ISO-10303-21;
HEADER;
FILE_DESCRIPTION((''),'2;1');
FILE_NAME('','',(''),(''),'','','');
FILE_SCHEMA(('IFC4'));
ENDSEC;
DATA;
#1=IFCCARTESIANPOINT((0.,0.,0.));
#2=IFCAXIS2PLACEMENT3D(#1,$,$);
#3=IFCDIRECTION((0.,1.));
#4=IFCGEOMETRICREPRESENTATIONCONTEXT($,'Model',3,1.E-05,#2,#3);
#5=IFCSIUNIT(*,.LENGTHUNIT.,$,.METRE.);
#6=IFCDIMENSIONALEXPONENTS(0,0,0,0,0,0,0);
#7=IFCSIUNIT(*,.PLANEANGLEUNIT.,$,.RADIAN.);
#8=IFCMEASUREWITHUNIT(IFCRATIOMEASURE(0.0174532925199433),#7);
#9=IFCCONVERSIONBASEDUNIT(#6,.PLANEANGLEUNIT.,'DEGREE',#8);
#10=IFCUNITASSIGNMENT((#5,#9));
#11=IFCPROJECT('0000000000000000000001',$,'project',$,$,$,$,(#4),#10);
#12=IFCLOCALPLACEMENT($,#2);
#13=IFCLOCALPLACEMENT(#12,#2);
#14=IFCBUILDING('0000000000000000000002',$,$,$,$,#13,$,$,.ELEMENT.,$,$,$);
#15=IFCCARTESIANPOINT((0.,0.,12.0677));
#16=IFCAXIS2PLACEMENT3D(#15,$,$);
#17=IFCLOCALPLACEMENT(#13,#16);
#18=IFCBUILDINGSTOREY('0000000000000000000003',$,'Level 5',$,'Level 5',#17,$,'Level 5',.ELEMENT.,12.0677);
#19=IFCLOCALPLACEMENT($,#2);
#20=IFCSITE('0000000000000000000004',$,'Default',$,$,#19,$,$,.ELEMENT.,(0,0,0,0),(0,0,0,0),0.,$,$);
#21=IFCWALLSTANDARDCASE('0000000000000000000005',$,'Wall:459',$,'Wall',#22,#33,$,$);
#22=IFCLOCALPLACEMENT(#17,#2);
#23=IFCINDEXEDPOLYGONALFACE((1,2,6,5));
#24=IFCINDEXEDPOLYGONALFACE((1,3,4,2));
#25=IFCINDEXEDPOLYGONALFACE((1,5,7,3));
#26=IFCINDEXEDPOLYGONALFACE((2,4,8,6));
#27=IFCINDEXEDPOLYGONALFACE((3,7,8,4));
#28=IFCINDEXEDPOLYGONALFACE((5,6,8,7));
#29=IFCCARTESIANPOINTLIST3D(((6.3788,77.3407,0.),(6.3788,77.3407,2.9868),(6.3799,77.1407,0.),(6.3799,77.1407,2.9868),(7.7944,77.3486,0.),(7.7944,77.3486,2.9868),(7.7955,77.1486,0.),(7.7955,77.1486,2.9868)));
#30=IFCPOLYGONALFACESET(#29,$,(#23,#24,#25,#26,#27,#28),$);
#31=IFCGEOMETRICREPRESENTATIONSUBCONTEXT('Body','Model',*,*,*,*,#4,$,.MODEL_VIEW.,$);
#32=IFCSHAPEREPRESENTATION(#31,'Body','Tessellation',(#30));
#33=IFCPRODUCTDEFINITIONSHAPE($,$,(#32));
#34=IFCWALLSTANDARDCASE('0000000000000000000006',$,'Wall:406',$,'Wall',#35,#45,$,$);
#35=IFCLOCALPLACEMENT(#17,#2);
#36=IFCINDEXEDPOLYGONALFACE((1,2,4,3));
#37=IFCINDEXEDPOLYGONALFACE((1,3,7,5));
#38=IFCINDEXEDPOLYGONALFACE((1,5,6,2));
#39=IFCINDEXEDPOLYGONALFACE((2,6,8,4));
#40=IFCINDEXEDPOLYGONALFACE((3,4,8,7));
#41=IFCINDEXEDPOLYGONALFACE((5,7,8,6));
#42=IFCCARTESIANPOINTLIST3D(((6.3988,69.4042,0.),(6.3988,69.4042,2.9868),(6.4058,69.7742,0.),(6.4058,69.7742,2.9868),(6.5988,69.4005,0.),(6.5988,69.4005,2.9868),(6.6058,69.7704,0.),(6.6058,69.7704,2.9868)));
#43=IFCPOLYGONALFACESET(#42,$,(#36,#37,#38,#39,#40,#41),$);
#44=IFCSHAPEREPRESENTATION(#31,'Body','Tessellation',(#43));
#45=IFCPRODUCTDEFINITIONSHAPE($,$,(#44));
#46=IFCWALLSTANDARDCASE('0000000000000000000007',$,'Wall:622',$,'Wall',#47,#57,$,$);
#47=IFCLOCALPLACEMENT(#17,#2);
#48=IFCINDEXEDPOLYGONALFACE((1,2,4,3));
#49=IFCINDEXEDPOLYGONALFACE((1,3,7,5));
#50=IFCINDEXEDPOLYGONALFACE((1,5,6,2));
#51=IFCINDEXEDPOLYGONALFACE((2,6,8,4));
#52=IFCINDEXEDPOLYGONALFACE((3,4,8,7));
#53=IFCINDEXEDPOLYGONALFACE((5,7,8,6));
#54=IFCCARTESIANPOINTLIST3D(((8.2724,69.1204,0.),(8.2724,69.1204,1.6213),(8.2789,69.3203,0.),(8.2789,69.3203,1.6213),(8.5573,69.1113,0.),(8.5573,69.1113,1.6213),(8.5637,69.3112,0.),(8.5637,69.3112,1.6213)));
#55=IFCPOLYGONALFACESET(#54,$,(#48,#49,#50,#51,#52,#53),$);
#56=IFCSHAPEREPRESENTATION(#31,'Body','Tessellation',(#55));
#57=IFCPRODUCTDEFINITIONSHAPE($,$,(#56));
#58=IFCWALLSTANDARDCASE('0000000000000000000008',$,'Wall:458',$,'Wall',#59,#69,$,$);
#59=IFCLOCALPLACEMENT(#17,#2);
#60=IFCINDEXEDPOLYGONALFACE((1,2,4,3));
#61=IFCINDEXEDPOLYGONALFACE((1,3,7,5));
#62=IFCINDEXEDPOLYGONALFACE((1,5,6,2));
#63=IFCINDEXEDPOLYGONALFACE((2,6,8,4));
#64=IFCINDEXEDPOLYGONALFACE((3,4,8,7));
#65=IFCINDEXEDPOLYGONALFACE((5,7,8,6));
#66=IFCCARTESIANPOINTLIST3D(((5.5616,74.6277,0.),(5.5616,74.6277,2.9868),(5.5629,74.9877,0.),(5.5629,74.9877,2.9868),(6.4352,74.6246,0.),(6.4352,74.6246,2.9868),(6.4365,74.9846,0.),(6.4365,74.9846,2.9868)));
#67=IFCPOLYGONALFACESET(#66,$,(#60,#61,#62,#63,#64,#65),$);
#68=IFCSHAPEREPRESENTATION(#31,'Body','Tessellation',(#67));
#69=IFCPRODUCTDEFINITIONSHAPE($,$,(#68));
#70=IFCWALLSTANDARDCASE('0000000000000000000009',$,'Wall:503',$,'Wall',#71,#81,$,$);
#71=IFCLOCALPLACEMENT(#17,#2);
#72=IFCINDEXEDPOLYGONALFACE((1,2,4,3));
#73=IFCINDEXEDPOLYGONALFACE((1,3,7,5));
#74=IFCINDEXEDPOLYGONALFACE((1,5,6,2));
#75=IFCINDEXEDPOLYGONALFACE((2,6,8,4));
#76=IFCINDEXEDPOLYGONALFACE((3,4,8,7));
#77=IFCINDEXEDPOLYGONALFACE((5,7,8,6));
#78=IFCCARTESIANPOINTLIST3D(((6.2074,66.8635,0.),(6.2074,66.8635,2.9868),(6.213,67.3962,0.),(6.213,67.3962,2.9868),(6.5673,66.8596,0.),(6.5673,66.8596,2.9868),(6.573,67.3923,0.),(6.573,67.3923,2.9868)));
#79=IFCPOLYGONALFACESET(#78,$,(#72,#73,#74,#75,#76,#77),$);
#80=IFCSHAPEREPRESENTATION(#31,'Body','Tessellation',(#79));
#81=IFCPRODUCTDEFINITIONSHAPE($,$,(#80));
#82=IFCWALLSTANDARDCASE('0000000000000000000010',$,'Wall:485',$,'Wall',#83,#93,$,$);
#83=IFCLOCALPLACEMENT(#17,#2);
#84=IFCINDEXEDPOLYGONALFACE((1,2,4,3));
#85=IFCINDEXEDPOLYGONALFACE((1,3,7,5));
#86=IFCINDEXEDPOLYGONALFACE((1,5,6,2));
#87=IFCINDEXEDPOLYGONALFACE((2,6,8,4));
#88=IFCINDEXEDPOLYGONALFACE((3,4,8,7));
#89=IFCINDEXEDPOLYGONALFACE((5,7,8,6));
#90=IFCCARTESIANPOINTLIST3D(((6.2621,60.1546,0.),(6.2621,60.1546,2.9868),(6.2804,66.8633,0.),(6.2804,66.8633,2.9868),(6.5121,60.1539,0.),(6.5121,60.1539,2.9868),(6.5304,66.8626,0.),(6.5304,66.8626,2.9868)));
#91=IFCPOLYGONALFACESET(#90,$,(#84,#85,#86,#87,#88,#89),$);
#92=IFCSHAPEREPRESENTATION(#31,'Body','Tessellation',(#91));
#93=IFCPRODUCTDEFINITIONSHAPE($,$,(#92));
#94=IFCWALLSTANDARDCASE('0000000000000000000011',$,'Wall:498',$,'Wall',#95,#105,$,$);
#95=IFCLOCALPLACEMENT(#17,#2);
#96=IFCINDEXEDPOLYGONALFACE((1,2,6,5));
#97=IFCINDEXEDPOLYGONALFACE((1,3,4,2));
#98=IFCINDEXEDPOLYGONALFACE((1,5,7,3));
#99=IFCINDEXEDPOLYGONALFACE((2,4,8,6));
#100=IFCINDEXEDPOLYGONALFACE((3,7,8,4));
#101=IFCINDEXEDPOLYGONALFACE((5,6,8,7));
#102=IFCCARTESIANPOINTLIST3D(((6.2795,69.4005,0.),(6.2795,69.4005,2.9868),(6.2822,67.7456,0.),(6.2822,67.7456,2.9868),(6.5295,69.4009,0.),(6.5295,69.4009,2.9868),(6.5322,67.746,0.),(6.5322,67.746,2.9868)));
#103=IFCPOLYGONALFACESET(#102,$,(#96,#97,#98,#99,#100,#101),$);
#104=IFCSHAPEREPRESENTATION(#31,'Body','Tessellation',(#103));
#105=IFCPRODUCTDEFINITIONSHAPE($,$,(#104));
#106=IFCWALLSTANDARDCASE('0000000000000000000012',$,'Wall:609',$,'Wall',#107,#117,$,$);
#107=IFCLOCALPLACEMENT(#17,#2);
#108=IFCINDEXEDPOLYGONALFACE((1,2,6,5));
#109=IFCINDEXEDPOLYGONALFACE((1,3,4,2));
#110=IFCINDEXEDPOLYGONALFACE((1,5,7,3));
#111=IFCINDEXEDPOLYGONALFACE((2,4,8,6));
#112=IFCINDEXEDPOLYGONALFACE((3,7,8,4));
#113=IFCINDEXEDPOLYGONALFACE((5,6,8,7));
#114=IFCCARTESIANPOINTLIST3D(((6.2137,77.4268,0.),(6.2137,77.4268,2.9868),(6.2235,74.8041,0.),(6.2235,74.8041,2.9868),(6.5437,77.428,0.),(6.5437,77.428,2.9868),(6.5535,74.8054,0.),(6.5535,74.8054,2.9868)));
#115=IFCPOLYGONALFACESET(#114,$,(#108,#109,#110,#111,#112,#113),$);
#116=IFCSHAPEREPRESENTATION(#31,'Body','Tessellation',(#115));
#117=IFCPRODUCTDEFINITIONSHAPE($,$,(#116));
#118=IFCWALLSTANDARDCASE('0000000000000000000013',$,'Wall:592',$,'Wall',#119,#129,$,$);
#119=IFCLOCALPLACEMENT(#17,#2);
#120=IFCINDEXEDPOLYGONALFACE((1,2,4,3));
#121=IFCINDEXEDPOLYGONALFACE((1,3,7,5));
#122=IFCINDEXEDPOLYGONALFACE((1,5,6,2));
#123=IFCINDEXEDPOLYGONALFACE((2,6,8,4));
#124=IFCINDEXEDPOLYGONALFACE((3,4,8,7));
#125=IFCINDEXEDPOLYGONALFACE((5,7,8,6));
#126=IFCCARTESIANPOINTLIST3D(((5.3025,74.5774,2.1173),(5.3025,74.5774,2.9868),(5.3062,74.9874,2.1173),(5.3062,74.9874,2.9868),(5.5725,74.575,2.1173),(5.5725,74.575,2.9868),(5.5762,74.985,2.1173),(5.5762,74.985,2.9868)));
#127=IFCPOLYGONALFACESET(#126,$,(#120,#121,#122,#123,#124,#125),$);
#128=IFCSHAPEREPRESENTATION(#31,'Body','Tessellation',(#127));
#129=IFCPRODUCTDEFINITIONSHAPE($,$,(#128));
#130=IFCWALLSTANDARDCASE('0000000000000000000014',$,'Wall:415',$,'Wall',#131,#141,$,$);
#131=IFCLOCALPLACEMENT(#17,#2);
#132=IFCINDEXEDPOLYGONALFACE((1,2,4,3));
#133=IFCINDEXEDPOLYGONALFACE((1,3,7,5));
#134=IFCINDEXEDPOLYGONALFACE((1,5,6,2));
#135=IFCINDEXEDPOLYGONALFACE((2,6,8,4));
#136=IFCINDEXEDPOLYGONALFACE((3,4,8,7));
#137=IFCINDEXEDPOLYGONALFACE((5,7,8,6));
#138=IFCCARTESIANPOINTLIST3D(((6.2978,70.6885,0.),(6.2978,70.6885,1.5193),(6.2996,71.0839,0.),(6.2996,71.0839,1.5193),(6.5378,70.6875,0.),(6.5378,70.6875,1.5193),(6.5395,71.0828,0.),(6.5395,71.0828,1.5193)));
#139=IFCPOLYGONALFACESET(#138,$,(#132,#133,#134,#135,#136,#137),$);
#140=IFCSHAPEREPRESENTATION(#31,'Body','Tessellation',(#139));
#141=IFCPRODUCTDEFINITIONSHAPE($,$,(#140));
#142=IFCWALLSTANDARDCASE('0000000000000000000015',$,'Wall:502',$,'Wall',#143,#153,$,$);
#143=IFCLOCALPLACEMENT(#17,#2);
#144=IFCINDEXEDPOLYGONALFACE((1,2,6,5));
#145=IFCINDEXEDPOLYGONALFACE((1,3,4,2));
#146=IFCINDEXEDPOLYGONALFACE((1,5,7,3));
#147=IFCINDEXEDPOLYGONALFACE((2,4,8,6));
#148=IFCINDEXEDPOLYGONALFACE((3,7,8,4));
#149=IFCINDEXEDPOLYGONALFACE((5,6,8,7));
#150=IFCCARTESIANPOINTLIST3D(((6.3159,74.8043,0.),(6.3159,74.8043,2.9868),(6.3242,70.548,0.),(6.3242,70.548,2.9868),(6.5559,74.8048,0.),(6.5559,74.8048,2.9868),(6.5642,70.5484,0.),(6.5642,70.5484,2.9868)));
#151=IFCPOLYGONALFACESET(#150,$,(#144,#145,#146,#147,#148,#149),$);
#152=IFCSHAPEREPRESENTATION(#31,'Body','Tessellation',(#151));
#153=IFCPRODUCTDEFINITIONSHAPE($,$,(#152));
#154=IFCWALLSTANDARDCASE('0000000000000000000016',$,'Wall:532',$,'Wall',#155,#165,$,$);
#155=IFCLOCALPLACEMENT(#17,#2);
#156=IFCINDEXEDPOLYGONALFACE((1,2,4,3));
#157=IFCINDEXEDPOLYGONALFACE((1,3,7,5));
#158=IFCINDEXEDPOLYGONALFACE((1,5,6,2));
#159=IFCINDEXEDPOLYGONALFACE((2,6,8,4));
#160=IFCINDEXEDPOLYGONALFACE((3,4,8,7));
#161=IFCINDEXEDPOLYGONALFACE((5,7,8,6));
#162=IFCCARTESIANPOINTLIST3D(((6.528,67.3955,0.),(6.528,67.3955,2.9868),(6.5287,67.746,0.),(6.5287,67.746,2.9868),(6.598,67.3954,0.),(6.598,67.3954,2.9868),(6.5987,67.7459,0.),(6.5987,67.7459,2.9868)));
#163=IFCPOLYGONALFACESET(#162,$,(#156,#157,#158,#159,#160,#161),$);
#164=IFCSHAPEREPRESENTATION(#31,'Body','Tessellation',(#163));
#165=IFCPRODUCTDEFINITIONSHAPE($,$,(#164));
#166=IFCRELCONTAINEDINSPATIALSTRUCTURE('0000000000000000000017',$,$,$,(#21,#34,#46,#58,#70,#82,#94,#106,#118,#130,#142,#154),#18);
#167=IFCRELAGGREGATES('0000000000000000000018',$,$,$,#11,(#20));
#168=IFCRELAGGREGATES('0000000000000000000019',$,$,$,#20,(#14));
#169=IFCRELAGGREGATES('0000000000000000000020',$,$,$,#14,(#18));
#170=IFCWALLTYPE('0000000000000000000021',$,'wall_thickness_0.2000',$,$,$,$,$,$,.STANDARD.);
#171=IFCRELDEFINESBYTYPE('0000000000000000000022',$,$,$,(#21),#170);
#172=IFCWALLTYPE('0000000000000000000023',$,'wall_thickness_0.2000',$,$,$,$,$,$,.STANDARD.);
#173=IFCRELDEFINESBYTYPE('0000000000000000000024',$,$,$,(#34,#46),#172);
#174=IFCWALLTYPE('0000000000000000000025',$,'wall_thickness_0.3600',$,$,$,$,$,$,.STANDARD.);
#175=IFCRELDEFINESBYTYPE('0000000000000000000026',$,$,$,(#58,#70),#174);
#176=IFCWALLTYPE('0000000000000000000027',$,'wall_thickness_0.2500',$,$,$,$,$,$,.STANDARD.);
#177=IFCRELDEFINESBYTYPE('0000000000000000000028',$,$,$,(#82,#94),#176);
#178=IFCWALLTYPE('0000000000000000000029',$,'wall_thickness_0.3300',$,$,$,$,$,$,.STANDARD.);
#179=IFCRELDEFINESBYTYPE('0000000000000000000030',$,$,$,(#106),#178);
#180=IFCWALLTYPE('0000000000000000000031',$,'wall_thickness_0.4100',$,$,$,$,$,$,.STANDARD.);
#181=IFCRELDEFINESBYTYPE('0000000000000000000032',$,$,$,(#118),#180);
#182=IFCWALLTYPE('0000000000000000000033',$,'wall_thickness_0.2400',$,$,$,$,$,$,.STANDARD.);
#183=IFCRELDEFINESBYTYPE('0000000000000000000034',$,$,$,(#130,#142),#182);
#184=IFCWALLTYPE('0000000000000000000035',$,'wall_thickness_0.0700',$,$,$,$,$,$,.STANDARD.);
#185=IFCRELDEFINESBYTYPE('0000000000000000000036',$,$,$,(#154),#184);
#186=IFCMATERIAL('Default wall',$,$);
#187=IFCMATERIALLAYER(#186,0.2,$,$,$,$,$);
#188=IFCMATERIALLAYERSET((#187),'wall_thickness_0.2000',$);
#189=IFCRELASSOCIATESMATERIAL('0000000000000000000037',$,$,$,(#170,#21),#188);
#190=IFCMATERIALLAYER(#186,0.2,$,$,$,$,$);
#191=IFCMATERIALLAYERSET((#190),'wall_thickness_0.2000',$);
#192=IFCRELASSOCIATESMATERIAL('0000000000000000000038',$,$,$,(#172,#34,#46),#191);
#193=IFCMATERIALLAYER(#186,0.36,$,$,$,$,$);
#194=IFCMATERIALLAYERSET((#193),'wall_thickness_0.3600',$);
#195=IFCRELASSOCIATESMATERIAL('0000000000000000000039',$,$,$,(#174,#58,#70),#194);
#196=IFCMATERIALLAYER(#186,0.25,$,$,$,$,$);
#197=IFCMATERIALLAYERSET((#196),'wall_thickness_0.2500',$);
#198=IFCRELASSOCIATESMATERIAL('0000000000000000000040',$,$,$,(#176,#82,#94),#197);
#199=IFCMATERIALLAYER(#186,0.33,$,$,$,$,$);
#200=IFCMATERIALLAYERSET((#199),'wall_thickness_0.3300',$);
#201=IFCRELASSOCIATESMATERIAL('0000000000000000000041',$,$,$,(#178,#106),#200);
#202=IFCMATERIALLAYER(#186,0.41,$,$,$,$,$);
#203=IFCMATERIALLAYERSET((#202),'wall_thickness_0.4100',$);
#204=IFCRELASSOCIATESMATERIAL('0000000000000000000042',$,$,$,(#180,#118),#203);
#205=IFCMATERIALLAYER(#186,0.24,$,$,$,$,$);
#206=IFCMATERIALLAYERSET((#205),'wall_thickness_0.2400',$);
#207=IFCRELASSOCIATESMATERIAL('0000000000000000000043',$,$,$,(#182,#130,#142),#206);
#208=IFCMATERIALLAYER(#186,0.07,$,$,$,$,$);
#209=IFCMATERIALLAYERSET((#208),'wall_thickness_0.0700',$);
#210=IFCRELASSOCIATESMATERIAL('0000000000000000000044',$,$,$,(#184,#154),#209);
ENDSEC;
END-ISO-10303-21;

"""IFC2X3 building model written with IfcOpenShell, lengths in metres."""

from ifc_helpers import new_model, entity, si_unit, converted_unit, direction, frame, origin, place, context, subcontext, project, spatial, polyline, outline, extrude, material, layer, layer_set, layer_usage, type_object, element, save


model = new_model("IFC2X3")

# Units and contexts
model_context = context("Model", 3, precision=1e-05, world=origin(), true_north=direction((0.0, 1.0)))
body_context = subcontext(model_context, "Body", "Model", "MODEL_VIEW")
ifc_project = project(units=[si_unit("LENGTHUNIT", "METRE"), converted_unit("PLANEANGLEUNIT", "DEGREE", entity("IfcRatioMeasure", 0.0174532925199433), si_unit("PLANEANGLEUNIT", "RADIAN"), dimensions=[0, 0, 0, 0, 0, 0, 0])], contexts=[model_context])

# Site, building, storey
site_placement = place(None, origin())
site = spatial("IfcSite", under=ifc_project, at=site_placement, Name="Default", CompositionType="ELEMENT", RefLatitude=(0, 0, 0, 0), RefLongitude=(0, 0, 0, 0), RefElevation=0.0)
placement_1 = place(None, origin())
building_placement = place(placement_1, origin())
building = spatial("IfcBuilding", under=site, at=building_placement, CompositionType="ELEMENT")
storey_placement = place(building_placement, frame((0.0, 0.0, 12.0677)))
storey = spatial("IfcBuildingStorey", under=building, at=storey_placement, Name="Level 5", ObjectType="Level 5", LongName="Level 5", CompositionType="ELEMENT", Elevation=12.0677)

# Walls
ifc_material_1 = material(Name="Default wall")
ifc_layer_1 = layer(ifc_material_1, 0.2)
ifc_layer_set_1 = layer_set([ifc_layer_1], Name="wall_thickness_0.2000")
ifc_layer_usage_1 = layer_usage(ifc_layer_set_1, "AXIS2", "POSITIVE", -0.1)
wall_type_1 = type_object("IfcWallType", Name="wall_thickness_0.2000", PredefinedType="STANDARD", material=ifc_layer_set_1)
wall_1_placement = place(storey_placement, frame((6.3794, 77.2407, 0.0), z_axis=(0.0, 0.0, 1.0), x_axis=(0.999984, 0.005578, 0.0)))
element("IfcWallStandardCase", 1, at=wall_1_placement, inside=storey, type_object=wall_type_1, material=ifc_layer_usage_1, Name="Wall:459", ObjectType="Wall", context=body_context, shape_type="SweptSolid", body=[
    extrude(outline(polyline([(1.4156, -0.1), (1.4156, 0.1), (0.0, 0.1), (0.0, -0.1), (1.4156, -0.1)])), origin(), (0.0, 0.0, 1.0), 2.9868),
])
ifc_layer_2 = layer(ifc_material_1, 0.2)
ifc_layer_set_2 = layer_set([ifc_layer_2], Name="wall_thickness_0.2000")
ifc_layer_usage_2 = layer_usage(ifc_layer_set_2, "AXIS2", "POSITIVE", -0.1)
wall_type_2 = type_object("IfcWallType", Name="wall_thickness_0.2000", PredefinedType="STANDARD", material=ifc_layer_set_2)
wall_2_placement = place(storey_placement, frame((6.5058, 69.7723, 0.0), z_axis=(0.0, 0.0, 1.0), x_axis=(-0.018922, -0.999821, 0.0)))
element("IfcWallStandardCase", 2, at=wall_2_placement, inside=storey, type_object=wall_type_2, material=ifc_layer_usage_2, Name="Wall:406", ObjectType="Wall", context=body_context, shape_type="SweptSolid", body=[
    extrude(outline(polyline([(0.37, -0.1), (0.37, 0.1), (0.0, 0.1), (0.0, -0.1), (0.37, -0.1)])), origin(), (0.0, 0.0, 1.0), 2.9868),
])
wall_3_placement = place(storey_placement, frame((8.5605, 69.2113, 0.0), z_axis=(0.0, 0.0, 1.0), x_axis=(-0.999487, 0.032017, 0.0)))
element("IfcWallStandardCase", 3, at=wall_3_placement, inside=storey, type_object=wall_type_2, material=ifc_layer_usage_2, Name="Wall:622", ObjectType="Wall", context=body_context, shape_type="SweptSolid", body=[
    extrude(outline(polyline([(0.285, -0.1), (0.285, 0.1), (0.0, 0.1), (0.0, -0.1), (0.285, -0.1)])), origin(), (0.0, 0.0, 1.0), 1.6213),
])
ifc_layer_3 = layer(ifc_material_1, 0.36)
ifc_layer_set_3 = layer_set([ifc_layer_3], Name="wall_thickness_0.3600")
ifc_layer_usage_3 = layer_usage(ifc_layer_set_3, "AXIS2", "POSITIVE", -0.18)
wall_type_3 = type_object("IfcWallType", Name="wall_thickness_0.3600", PredefinedType="STANDARD", material=ifc_layer_set_3)
wall_4_placement = place(storey_placement, frame((5.5622, 74.8077, 0.0), z_axis=(0.0, 0.0, 1.0), x_axis=(0.999993, -0.003624, 0.0)))
element("IfcWallStandardCase", 4, at=wall_4_placement, inside=storey, type_object=wall_type_3, material=ifc_layer_usage_3, Name="Wall:458", ObjectType="Wall", context=body_context, shape_type="SweptSolid", body=[
    extrude(outline(polyline([(0.8737, -0.18), (0.8737, 0.18), (0.0, 0.18), (0.0, -0.18), (0.8737, -0.18)])), origin(), (0.0, 0.0, 1.0), 2.9868),
])
wall_5_placement = place(storey_placement, frame((6.393, 67.3942, 0.0), z_axis=(0.0, 0.0, 1.0), x_axis=(-0.010649, -0.999943, 0.0)))
element("IfcWallStandardCase", 5, at=wall_5_placement, inside=storey, type_object=wall_type_3, material=ifc_layer_usage_3, Name="Wall:503", ObjectType="Wall", context=body_context, shape_type="SweptSolid", body=[
    extrude(outline(polyline([(0.5327, -0.18), (0.5327, 0.18), (0.0, 0.18), (0.0, -0.18), (0.5327, -0.18)])), origin(), (0.0, 0.0, 1.0), 2.9868),
])
ifc_layer_4 = layer(ifc_material_1, 0.25)
ifc_layer_set_4 = layer_set([ifc_layer_4], Name="wall_thickness_0.2500")
ifc_layer_usage_4 = layer_usage(ifc_layer_set_4, "AXIS2", "POSITIVE", -0.125)
wall_type_4 = type_object("IfcWallType", Name="wall_thickness_0.2500", PredefinedType="STANDARD", material=ifc_layer_set_4)
wall_6_placement = place(storey_placement, frame((6.4054, 66.8629, 0.0), z_axis=(0.0, 0.0, 1.0), x_axis=(-0.002717, -0.999996, 0.0)))
element("IfcWallStandardCase", 6, at=wall_6_placement, inside=storey, type_object=wall_type_4, material=ifc_layer_usage_4, Name="Wall:485", ObjectType="Wall", context=body_context, shape_type="SweptSolid", body=[
    extrude(outline(polyline([(6.7087, -0.125), (6.7087, 0.125), (0.0, 0.125), (0.0, -0.125), (6.7087, -0.125)])), origin(), (0.0, 0.0, 1.0), 2.9868),
])
wall_7_placement = place(storey_placement, frame((6.4045, 69.4007, 0.0), z_axis=(0.0, 0.0, 1.0), x_axis=(0.001643, -0.999999, 0.0)))
element("IfcWallStandardCase", 7, at=wall_7_placement, inside=storey, type_object=wall_type_4, material=ifc_layer_usage_4, Name="Wall:498", ObjectType="Wall", context=body_context, shape_type="SweptSolid", body=[
    extrude(outline(polyline([(1.6549, -0.125), (1.6549, 0.125), (0.0, 0.125), (0.0, -0.125), (1.6549, -0.125)])), origin(), (0.0, 0.0, 1.0), 2.9868),
])
ifc_layer_5 = layer(ifc_material_1, 0.33)
ifc_layer_set_5 = layer_set([ifc_layer_5], Name="wall_thickness_0.3300")
ifc_layer_usage_5 = layer_usage(ifc_layer_set_5, "AXIS2", "POSITIVE", -0.165)
wall_type_5 = type_object("IfcWallType", Name="wall_thickness_0.3300", PredefinedType="STANDARD", material=ifc_layer_set_5)
wall_8_placement = place(storey_placement, frame((6.3787, 77.4274, 0.0), z_axis=(0.0, 0.0, 1.0), x_axis=(0.00376, -0.999993, 0.0)))
element("IfcWallStandardCase", 8, at=wall_8_placement, inside=storey, type_object=wall_type_5, material=ifc_layer_usage_5, Name="Wall:609", ObjectType="Wall", context=body_context, shape_type="SweptSolid", body=[
    extrude(outline(polyline([(2.6227, -0.165), (2.6227, 0.165), (0.0, 0.165), (0.0, -0.165), (2.6227, -0.165)])), origin(), (0.0, 0.0, 1.0), 2.9868),
])
ifc_layer_6 = layer(ifc_material_1, 0.41)
ifc_layer_set_6 = layer_set([ifc_layer_6], Name="wall_thickness_0.4100")
ifc_layer_usage_6 = layer_usage(ifc_layer_set_6, "AXIS2", "POSITIVE", -0.205)
wall_type_6 = type_object("IfcWallType", Name="wall_thickness_0.4100", PredefinedType="STANDARD", material=ifc_layer_set_6)
placement_2 = place(building_placement, frame((0.0, 0.0, 14.185)))
wall_9_placement = place(placement_2, frame((5.3043, 74.7824, 0.0), z_axis=(0.0, 0.0, 1.0), x_axis=(0.999959, -0.009014, 0.0)))
element("IfcWallStandardCase", 9, at=wall_9_placement, inside=storey, type_object=wall_type_6, material=ifc_layer_usage_6, Name="Wall:592", ObjectType="Wall", context=body_context, shape_type="SweptSolid", body=[
    extrude(outline(polyline([(0.27, -0.205), (0.27, 0.205), (0.0, 0.205), (0.0, -0.205), (0.27, -0.205)])), origin(), (0.0, 0.0, 1.0), 0.8695),
])
ifc_layer_7 = layer(ifc_material_1, 0.24)
ifc_layer_set_7 = layer_set([ifc_layer_7], Name="wall_thickness_0.2400")
ifc_layer_usage_7 = layer_usage(ifc_layer_set_7, "AXIS2", "POSITIVE", -0.12)
wall_type_7 = type_object("IfcWallType", Name="wall_thickness_0.2400", PredefinedType="STANDARD", material=ifc_layer_set_7)
wall_10_placement = place(storey_placement, frame((6.4195, 71.0834, 0.0), z_axis=(0.0, 0.0, 1.0), x_axis=(-0.004367, -0.99999, 0.0)))
element("IfcWallStandardCase", 10, at=wall_10_placement, inside=storey, type_object=wall_type_7, material=ifc_layer_usage_7, Name="Wall:415", ObjectType="Wall", context=body_context, shape_type="SweptSolid", body=[
    extrude(outline(polyline([(0.3954, -0.12), (0.3954, 0.12), (0.0, 0.12), (0.0, -0.12), (0.3954, -0.12)])), origin(), (0.0, 0.0, 1.0), 1.5193),
])
wall_11_placement = place(storey_placement, frame((6.4359, 74.8046, 0.0), z_axis=(0.0, 0.0, 1.0), x_axis=(0.001967, -0.999998, 0.0)))
element("IfcWallStandardCase", 11, at=wall_11_placement, inside=storey, type_object=wall_type_7, material=ifc_layer_usage_7, Name="Wall:502", ObjectType="Wall", context=body_context, shape_type="SweptSolid", body=[
    extrude(outline(polyline([(4.2564, -0.12), (4.2564, 0.12), (0.0, 0.12), (0.0, -0.12), (4.2564, -0.12)])), origin(), (0.0, 0.0, 1.0), 2.9868),
])
ifc_layer_8 = layer(ifc_material_1, 0.07)
ifc_layer_set_8 = layer_set([ifc_layer_8], Name="wall_thickness_0.0700")
ifc_layer_usage_8 = layer_usage(ifc_layer_set_8, "AXIS2", "POSITIVE", -0.035)
wall_type_8 = type_object("IfcWallType", Name="wall_thickness_0.0700", PredefinedType="STANDARD", material=ifc_layer_set_8)
wall_12_placement = place(storey_placement, frame((6.5637, 67.7459, 0.0), z_axis=(0.0, 0.0, 1.0), x_axis=(-0.002, -0.999998, 0.0)))
element("IfcWallStandardCase", 12, at=wall_12_placement, inside=storey, type_object=wall_type_8, material=ifc_layer_usage_8, Name="Wall:532", ObjectType="Wall", context=body_context, shape_type="SweptSolid", body=[
    extrude(outline(polyline([(0.3505, -0.035), (0.3505, 0.035), (0.0, 0.035), (0.0, -0.035), (0.3505, -0.035)])), origin(), (0.0, 0.0, 1.0), 2.9868),
])

save(model, "model.ifc")
